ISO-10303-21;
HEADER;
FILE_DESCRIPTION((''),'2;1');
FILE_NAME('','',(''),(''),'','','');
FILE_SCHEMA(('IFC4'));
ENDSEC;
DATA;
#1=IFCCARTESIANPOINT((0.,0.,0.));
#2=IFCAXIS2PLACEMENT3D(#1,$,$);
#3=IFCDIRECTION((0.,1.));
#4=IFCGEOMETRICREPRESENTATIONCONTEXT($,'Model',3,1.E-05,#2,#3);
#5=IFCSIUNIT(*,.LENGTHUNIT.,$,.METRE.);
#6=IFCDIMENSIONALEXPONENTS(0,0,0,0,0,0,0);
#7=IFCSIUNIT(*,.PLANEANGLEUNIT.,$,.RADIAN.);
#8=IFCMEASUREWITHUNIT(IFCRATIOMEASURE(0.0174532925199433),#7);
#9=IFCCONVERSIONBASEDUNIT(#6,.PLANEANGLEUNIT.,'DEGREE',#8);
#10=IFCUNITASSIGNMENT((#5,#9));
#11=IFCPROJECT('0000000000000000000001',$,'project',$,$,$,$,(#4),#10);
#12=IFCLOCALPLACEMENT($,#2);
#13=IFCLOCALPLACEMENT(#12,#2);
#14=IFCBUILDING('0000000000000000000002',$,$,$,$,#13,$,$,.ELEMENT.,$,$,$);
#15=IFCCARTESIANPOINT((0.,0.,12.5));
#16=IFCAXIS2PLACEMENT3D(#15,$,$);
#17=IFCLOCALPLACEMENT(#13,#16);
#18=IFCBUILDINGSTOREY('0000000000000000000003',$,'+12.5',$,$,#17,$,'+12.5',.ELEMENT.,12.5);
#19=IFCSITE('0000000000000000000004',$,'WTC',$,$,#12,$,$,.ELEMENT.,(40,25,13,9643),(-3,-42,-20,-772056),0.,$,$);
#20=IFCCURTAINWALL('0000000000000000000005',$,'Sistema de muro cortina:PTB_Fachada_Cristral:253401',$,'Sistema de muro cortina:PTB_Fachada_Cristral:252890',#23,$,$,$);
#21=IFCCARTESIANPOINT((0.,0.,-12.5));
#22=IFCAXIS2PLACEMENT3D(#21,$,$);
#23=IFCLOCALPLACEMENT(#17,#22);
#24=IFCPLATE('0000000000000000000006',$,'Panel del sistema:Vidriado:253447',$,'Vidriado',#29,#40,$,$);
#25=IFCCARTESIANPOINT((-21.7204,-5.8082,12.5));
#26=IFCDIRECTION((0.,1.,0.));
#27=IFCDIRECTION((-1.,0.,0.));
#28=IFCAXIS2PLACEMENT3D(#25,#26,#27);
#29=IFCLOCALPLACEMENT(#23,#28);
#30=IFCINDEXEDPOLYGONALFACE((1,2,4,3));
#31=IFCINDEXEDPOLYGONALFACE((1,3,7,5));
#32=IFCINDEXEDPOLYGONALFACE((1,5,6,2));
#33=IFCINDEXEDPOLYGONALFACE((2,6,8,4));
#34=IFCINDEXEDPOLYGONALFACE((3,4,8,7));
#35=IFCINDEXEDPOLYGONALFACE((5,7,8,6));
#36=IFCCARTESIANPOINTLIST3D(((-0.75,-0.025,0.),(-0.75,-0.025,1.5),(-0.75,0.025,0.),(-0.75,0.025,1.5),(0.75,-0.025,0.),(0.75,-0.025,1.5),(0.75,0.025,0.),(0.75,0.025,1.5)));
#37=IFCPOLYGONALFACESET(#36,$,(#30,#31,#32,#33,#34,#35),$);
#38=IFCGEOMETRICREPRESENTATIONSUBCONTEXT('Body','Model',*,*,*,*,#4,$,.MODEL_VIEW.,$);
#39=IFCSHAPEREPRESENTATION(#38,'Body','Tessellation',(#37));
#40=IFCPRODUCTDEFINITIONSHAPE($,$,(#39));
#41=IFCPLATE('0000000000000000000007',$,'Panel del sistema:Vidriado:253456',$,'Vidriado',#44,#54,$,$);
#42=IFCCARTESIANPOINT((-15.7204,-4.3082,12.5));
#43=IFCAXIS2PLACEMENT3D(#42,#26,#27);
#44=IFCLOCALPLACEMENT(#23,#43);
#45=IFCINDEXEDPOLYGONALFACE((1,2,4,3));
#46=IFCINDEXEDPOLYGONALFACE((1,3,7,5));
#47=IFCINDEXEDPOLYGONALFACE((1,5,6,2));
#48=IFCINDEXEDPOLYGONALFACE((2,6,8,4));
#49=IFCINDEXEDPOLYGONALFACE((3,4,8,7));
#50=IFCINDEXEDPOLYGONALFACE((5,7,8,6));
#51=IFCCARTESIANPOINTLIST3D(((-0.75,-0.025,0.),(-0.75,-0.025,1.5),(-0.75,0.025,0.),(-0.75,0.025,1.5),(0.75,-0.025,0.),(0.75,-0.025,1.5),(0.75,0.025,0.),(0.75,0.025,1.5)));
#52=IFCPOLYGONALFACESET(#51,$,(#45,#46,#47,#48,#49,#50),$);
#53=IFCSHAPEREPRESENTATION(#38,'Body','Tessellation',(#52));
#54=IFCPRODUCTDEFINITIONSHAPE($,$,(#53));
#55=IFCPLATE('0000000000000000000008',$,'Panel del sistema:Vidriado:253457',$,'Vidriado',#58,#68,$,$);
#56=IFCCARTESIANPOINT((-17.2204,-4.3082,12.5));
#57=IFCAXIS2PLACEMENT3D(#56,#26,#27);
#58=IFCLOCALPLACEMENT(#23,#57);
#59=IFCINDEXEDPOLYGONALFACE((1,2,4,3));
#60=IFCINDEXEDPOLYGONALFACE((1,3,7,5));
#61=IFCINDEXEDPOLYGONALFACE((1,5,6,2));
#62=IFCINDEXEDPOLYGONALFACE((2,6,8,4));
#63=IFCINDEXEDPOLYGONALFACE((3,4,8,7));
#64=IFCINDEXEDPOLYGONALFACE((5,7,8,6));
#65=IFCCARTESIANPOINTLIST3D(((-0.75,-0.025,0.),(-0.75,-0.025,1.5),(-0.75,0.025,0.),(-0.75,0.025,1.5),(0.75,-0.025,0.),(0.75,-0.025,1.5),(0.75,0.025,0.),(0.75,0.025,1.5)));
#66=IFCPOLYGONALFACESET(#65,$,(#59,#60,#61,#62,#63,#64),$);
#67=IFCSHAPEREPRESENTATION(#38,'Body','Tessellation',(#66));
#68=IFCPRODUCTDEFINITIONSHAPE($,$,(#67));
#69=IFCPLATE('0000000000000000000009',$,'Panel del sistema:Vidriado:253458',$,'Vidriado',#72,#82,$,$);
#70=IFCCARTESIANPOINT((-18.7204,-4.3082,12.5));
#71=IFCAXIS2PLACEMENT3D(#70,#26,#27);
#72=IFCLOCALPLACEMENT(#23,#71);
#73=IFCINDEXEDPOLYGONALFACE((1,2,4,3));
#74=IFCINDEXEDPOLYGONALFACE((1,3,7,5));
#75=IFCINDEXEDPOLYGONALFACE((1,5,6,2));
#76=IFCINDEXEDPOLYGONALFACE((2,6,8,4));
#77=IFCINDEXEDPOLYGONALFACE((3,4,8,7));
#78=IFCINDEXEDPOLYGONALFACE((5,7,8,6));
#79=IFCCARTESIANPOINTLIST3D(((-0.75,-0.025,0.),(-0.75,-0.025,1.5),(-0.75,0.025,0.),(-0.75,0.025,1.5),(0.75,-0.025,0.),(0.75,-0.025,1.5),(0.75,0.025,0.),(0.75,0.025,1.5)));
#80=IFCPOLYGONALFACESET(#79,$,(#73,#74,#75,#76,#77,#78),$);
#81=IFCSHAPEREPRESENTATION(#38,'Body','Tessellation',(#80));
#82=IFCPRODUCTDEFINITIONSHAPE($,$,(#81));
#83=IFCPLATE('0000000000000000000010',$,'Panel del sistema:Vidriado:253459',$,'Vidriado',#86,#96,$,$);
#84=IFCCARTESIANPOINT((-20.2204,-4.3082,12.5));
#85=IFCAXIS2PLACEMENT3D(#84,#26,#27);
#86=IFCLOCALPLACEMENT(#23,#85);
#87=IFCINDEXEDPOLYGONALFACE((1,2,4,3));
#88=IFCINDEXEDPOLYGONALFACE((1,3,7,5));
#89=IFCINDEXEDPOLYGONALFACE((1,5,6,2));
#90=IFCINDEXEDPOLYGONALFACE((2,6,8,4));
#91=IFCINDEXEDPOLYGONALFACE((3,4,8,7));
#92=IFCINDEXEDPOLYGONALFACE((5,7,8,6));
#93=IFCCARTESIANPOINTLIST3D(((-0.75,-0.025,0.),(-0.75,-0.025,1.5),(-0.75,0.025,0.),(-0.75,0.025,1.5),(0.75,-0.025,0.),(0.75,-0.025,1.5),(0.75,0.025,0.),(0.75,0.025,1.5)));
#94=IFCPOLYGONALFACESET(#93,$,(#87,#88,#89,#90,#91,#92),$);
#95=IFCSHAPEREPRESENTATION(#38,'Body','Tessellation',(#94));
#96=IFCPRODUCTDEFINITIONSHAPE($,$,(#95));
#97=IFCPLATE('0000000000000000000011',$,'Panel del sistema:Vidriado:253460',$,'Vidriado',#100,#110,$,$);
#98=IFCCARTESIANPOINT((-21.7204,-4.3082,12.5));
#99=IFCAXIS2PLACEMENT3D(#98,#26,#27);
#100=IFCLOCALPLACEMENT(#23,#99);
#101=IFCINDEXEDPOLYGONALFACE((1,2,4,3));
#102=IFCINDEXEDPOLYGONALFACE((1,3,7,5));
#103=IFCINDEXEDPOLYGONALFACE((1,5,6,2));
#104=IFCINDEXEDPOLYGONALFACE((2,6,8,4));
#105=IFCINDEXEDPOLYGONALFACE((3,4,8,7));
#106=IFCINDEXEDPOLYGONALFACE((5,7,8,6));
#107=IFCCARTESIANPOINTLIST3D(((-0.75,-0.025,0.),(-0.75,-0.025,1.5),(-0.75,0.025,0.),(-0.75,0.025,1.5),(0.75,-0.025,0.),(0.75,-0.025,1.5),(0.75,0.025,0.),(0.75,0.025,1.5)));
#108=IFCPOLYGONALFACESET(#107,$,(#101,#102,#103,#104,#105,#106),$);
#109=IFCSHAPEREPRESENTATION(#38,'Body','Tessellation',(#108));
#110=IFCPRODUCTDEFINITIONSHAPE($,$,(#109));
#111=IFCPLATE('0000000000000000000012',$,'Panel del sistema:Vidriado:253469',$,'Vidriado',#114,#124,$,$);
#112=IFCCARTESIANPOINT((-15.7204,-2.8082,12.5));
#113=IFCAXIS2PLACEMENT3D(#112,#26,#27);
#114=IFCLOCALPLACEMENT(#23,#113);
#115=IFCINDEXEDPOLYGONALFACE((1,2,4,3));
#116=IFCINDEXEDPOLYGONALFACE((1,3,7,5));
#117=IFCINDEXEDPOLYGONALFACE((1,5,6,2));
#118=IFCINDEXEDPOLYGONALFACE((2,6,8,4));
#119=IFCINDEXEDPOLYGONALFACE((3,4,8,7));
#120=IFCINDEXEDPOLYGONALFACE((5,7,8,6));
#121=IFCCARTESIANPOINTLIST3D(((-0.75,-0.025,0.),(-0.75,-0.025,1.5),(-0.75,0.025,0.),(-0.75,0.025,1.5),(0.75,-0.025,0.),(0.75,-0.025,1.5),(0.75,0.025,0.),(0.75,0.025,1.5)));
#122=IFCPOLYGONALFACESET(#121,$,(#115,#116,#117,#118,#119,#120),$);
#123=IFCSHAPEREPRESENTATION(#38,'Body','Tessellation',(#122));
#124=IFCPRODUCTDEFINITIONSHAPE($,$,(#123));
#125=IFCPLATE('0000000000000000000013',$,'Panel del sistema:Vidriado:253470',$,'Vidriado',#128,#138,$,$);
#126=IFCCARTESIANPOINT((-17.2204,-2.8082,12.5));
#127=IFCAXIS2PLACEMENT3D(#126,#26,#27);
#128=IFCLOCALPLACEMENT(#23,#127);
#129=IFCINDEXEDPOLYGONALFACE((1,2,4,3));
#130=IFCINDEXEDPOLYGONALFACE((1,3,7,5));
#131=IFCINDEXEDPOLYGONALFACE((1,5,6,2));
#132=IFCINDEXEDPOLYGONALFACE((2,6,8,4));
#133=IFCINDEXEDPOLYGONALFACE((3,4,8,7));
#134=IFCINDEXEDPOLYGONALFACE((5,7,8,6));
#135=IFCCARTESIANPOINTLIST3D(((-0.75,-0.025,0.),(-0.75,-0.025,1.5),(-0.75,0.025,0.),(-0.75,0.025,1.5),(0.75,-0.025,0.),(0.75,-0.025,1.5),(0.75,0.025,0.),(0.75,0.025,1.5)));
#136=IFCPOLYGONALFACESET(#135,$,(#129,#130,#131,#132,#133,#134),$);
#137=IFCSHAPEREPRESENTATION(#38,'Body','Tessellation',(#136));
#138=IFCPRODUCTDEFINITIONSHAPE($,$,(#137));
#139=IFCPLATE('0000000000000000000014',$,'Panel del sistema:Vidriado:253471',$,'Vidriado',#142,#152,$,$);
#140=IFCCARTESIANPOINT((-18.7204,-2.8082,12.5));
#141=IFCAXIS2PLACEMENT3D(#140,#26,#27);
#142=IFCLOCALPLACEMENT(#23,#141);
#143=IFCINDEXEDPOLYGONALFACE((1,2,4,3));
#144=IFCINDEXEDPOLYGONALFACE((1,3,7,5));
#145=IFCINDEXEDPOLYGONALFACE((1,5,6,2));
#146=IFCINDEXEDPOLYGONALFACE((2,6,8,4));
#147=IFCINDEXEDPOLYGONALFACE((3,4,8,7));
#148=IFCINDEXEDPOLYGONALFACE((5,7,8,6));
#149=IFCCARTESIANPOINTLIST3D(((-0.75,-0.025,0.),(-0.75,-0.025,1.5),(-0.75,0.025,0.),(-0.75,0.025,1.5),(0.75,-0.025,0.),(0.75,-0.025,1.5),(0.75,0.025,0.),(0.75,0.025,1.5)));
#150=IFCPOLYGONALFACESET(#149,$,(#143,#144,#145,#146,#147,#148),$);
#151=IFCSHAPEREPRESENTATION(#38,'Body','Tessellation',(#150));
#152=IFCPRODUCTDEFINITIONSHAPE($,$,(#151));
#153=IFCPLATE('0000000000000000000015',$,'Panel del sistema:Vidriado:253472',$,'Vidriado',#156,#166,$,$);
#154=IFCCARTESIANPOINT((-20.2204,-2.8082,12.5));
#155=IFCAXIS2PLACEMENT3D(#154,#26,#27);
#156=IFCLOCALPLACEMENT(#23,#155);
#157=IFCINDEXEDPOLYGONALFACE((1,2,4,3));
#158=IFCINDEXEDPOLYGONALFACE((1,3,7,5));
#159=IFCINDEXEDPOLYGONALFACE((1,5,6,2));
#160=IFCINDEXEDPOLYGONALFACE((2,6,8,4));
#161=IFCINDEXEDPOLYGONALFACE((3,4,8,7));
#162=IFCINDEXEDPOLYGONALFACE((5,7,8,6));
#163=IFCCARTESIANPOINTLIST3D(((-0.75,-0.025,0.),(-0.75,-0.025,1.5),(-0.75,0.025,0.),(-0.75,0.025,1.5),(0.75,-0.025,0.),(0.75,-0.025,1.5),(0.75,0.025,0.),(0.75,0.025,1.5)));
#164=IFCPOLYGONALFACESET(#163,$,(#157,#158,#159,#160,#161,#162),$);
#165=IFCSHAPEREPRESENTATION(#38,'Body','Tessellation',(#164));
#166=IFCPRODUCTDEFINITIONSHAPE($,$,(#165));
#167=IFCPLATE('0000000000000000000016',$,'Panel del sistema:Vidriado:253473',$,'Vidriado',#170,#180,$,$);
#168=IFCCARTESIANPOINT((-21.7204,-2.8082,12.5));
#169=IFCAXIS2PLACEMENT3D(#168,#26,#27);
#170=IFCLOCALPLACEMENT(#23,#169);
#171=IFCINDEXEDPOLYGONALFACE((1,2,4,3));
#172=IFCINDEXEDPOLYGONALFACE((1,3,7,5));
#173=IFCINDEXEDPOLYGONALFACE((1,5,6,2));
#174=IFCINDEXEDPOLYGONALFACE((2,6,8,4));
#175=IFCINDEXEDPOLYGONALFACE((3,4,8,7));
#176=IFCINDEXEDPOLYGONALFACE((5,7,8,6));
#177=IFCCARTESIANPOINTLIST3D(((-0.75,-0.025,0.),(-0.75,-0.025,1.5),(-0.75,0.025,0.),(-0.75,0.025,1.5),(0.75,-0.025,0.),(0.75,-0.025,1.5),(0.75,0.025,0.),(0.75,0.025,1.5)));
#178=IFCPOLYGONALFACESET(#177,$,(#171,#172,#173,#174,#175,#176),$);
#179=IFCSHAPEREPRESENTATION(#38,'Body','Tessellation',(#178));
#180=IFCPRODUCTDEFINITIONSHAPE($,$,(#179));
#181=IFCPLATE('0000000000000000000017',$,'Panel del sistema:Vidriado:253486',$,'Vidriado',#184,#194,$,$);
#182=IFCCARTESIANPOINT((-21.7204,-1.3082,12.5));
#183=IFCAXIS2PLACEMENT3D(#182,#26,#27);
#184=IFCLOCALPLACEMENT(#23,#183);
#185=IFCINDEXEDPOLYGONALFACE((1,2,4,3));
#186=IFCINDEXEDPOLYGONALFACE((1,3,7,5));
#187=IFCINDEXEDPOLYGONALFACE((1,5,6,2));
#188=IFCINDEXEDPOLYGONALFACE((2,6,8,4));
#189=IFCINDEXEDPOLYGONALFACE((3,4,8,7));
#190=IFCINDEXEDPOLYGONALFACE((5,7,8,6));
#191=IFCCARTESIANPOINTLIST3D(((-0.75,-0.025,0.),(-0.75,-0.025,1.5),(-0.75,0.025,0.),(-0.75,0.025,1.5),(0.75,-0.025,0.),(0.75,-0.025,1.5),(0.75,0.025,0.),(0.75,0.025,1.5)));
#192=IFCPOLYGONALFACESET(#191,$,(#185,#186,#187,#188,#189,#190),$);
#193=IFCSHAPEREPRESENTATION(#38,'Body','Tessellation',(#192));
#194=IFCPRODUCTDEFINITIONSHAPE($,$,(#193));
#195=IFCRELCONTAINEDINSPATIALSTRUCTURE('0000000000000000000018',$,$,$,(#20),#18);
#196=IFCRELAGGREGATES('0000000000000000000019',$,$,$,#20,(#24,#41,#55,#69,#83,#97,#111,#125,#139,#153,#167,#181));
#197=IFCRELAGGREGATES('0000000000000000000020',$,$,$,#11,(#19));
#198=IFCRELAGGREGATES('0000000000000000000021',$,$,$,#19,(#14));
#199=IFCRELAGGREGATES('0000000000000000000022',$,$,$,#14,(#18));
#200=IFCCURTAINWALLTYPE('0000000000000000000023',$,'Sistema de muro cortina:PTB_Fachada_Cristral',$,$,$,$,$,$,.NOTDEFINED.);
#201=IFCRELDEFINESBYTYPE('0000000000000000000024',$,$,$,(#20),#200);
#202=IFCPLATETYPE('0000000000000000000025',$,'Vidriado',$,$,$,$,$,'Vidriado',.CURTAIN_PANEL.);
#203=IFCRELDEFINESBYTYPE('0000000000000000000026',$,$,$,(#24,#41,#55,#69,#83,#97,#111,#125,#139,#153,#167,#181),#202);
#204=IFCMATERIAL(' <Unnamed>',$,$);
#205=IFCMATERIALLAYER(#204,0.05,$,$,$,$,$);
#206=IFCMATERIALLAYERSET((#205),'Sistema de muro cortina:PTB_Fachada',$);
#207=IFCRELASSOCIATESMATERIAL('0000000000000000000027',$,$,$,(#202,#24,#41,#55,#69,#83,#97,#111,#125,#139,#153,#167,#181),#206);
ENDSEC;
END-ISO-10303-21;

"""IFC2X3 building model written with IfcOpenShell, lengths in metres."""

from ifc_helpers import new_model, entity, si_unit, converted_unit, direction, frame, origin, origin_2d_with_axis, place, context, subcontext, project, spatial, rectangle, extrude, source, transform, mapped, material, layer, layer_set, layer_usage, type_object, type_shapes, element, aggregate, save


model = new_model("IFC2X3")

# Units and contexts
model_context = context("Model", 3, precision=1e-05, world=origin(), true_north=direction((0.0, 1.0)))
body_context = subcontext(model_context, "Body", "Model", "MODEL_VIEW")
ifc_project = project(units=[si_unit("LENGTHUNIT", "METRE"), converted_unit("PLANEANGLEUNIT", "DEGREE", entity("IfcRatioMeasure", 0.0174532925199433), si_unit("PLANEANGLEUNIT", "RADIAN"), dimensions=[0, 0, 0, 0, 0, 0, 0])], contexts=[model_context])

# Site, building, storey
site_placement = place(None, origin())
site = spatial("IfcSite", under=ifc_project, at=site_placement, Name="WTC", CompositionType="ELEMENT", RefLatitude=(40, 25, 13, 9643), RefLongitude=(-3, -42, -20, -772056), RefElevation=0.0)
building_placement = place(site_placement, origin())
building = spatial("IfcBuilding", under=site, at=building_placement, CompositionType="ELEMENT")
storey_placement = place(building_placement, frame((0.0, 0.0, 12.5)))
storey = spatial("IfcBuildingStorey", under=building, at=storey_placement, Name="+12.5", LongName="+12.5", CompositionType="ELEMENT", Elevation=12.5)

# Curtain wall, plates
curtain_wall_type = type_object("IfcCurtainWallType", Name="Sistema de muro cortina:PTB_Fachada_Cristral", PredefinedType="NOTDEFINED")
curtain_wall_placement = place(storey_placement, frame((0.0, 0.0, -12.5)))
curtain_wall = element("IfcCurtainWall", 1, at=curtain_wall_placement, inside=storey, type_object=curtain_wall_type, Name="Sistema de muro cortina:PTB_Fachada_Cristral:253401", ObjectType="Sistema de muro cortina:PTB_Fachada_Cristral:252890")
ifc_material = material(Name=" <Unnamed>")
ifc_layer = layer(ifc_material, 0.05)
ifc_layer_set = layer_set([ifc_layer], Name="Sistema de muro cortina:PTB_Fachada")
plate_type = type_object("IfcPlateType", Name="Vidriado", ElementType="Vidriado", PredefinedType="CURTAIN_PANEL", material=ifc_layer_set)
shared_shape = source(origin(), body_context, "Body", "SweptSolid", [
    extrude(rectangle(XDim=0.05, YDim=1.5, at=origin_2d_with_axis()), frame((0.0, 0.0, 0.0), z_axis=(0.0, 0.0, 1.0), x_axis=(0.0, 1.0, 0.0)), (0.0, 0.0, 1.0), 1.5),
])
type_shapes(plate_type, [shared_shape])
ifc_layer_usage_1 = layer_usage(ifc_layer_set, "AXIS3", "POSITIVE", 0.0)
plate_1_placement = place(curtain_wall_placement, frame((-21.7204, -5.8082, 12.5), z_axis=(0.0, 1.0, 0.0), x_axis=(-1.0, 0.0, 0.0)))
plate_1 = element("IfcPlate", 2, at=plate_1_placement, type_object=plate_type, material=ifc_layer_usage_1, Name="Panel del sistema:Vidriado:253447", ObjectType="Vidriado", context=body_context, shape_type="MappedRepresentation", body=[
    mapped(shared_shape, transform((0.0, 0.0, 0.0), scale=1.0)),
])
ifc_layer_usage_2 = layer_usage(ifc_layer_set, "AXIS3", "POSITIVE", 0.0)
plate_2_placement = place(curtain_wall_placement, frame((-15.7204, -4.3082, 12.5), z_axis=(0.0, 1.0, 0.0), x_axis=(-1.0, 0.0, 0.0)))
plate_2 = element("IfcPlate", 3, at=plate_2_placement, type_object=plate_type, material=ifc_layer_usage_2, Name="Panel del sistema:Vidriado:253456", ObjectType="Vidriado", context=body_context, shape_type="MappedRepresentation", body=[
    mapped(shared_shape, transform((0.0, 0.0, 0.0), scale=1.0)),
])
ifc_layer_usage_3 = layer_usage(ifc_layer_set, "AXIS3", "POSITIVE", 0.0)
plate_3_placement = place(curtain_wall_placement, frame((-17.2204, -4.3082, 12.5), z_axis=(0.0, 1.0, 0.0), x_axis=(-1.0, 0.0, 0.0)))
plate_3 = element("IfcPlate", 4, at=plate_3_placement, type_object=plate_type, material=ifc_layer_usage_3, Name="Panel del sistema:Vidriado:253457", ObjectType="Vidriado", context=body_context, shape_type="MappedRepresentation", body=[
    mapped(shared_shape, transform((0.0, 0.0, 0.0), scale=1.0)),
])
ifc_layer_usage_4 = layer_usage(ifc_layer_set, "AXIS3", "POSITIVE", 0.0)
plate_4_placement = place(curtain_wall_placement, frame((-18.7204, -4.3082, 12.5), z_axis=(0.0, 1.0, 0.0), x_axis=(-1.0, 0.0, 0.0)))
plate_4 = element("IfcPlate", 5, at=plate_4_placement, type_object=plate_type, material=ifc_layer_usage_4, Name="Panel del sistema:Vidriado:253458", ObjectType="Vidriado", context=body_context, shape_type="MappedRepresentation", body=[
    mapped(shared_shape, transform((0.0, 0.0, 0.0), scale=1.0)),
])
ifc_layer_usage_5 = layer_usage(ifc_layer_set, "AXIS3", "POSITIVE", 0.0)
plate_5_placement = place(curtain_wall_placement, frame((-20.2204, -4.3082, 12.5), z_axis=(0.0, 1.0, 0.0), x_axis=(-1.0, 0.0, 0.0)))
plate_5 = element("IfcPlate", 6, at=plate_5_placement, type_object=plate_type, material=ifc_layer_usage_5, Name="Panel del sistema:Vidriado:253459", ObjectType="Vidriado", context=body_context, shape_type="MappedRepresentation", body=[
    mapped(shared_shape, transform((0.0, 0.0, 0.0), scale=1.0)),
])
ifc_layer_usage_6 = layer_usage(ifc_layer_set, "AXIS3", "POSITIVE", 0.0)
plate_6_placement = place(curtain_wall_placement, frame((-21.7204, -4.3082, 12.5), z_axis=(0.0, 1.0, 0.0), x_axis=(-1.0, 0.0, 0.0)))
plate_6 = element("IfcPlate", 7, at=plate_6_placement, type_object=plate_type, material=ifc_layer_usage_6, Name="Panel del sistema:Vidriado:253460", ObjectType="Vidriado", context=body_context, shape_type="MappedRepresentation", body=[
    mapped(shared_shape, transform((0.0, 0.0, 0.0), scale=1.0)),
])
ifc_layer_usage_7 = layer_usage(ifc_layer_set, "AXIS3", "POSITIVE", 0.0)
plate_7_placement = place(curtain_wall_placement, frame((-15.7204, -2.8082, 12.5), z_axis=(0.0, 1.0, 0.0), x_axis=(-1.0, 0.0, 0.0)))
plate_7 = element("IfcPlate", 8, at=plate_7_placement, type_object=plate_type, material=ifc_layer_usage_7, Name="Panel del sistema:Vidriado:253469", ObjectType="Vidriado", context=body_context, shape_type="MappedRepresentation", body=[
    mapped(shared_shape, transform((0.0, 0.0, 0.0), scale=1.0)),
])
ifc_layer_usage_8 = layer_usage(ifc_layer_set, "AXIS3", "POSITIVE", 0.0)
plate_8_placement = place(curtain_wall_placement, frame((-17.2204, -2.8082, 12.5), z_axis=(0.0, 1.0, 0.0), x_axis=(-1.0, 0.0, 0.0)))
plate_8 = element("IfcPlate", 9, at=plate_8_placement, type_object=plate_type, material=ifc_layer_usage_8, Name="Panel del sistema:Vidriado:253470", ObjectType="Vidriado", context=body_context, shape_type="MappedRepresentation", body=[
    mapped(shared_shape, transform((0.0, 0.0, 0.0), scale=1.0)),
])
ifc_layer_usage_9 = layer_usage(ifc_layer_set, "AXIS3", "POSITIVE", 0.0)
plate_9_placement = place(curtain_wall_placement, frame((-18.7204, -2.8082, 12.5), z_axis=(0.0, 1.0, 0.0), x_axis=(-1.0, 0.0, 0.0)))
plate_9 = element("IfcPlate", 10, at=plate_9_placement, type_object=plate_type, material=ifc_layer_usage_9, Name="Panel del sistema:Vidriado:253471", ObjectType="Vidriado", context=body_context, shape_type="MappedRepresentation", body=[
    mapped(shared_shape, transform((0.0, 0.0, 0.0), scale=1.0)),
])
ifc_layer_usage_10 = layer_usage(ifc_layer_set, "AXIS3", "POSITIVE", 0.0)
plate_10_placement = place(curtain_wall_placement, frame((-20.2204, -2.8082, 12.5), z_axis=(0.0, 1.0, 0.0), x_axis=(-1.0, 0.0, 0.0)))
plate_10 = element("IfcPlate", 11, at=plate_10_placement, type_object=plate_type, material=ifc_layer_usage_10, Name="Panel del sistema:Vidriado:253472", ObjectType="Vidriado", context=body_context, shape_type="MappedRepresentation", body=[
    mapped(shared_shape, transform((0.0, 0.0, 0.0), scale=1.0)),
])
ifc_layer_usage_11 = layer_usage(ifc_layer_set, "AXIS3", "POSITIVE", 0.0)
plate_11_placement = place(curtain_wall_placement, frame((-21.7204, -2.8082, 12.5), z_axis=(0.0, 1.0, 0.0), x_axis=(-1.0, 0.0, 0.0)))
plate_11 = element("IfcPlate", 12, at=plate_11_placement, type_object=plate_type, material=ifc_layer_usage_11, Name="Panel del sistema:Vidriado:253473", ObjectType="Vidriado", context=body_context, shape_type="MappedRepresentation", body=[
    mapped(shared_shape, transform((0.0, 0.0, 0.0), scale=1.0)),
])
ifc_layer_usage_12 = layer_usage(ifc_layer_set, "AXIS3", "POSITIVE", 0.0)
plate_12_placement = place(curtain_wall_placement, frame((-21.7204, -1.3082, 12.5), z_axis=(0.0, 1.0, 0.0), x_axis=(-1.0, 0.0, 0.0)))
plate_12 = element("IfcPlate", 13, at=plate_12_placement, type_object=plate_type, material=ifc_layer_usage_12, Name="Panel del sistema:Vidriado:253486", ObjectType="Vidriado", context=body_context, shape_type="MappedRepresentation", body=[
    mapped(shared_shape, transform((0.0, 0.0, 0.0), scale=1.0)),
])
aggregate(curtain_wall, [plate_1, plate_2, plate_3, plate_4, plate_5, plate_6, plate_7, plate_8, plate_9, plate_10, plate_11, plate_12])

save(model, "model.ifc")
